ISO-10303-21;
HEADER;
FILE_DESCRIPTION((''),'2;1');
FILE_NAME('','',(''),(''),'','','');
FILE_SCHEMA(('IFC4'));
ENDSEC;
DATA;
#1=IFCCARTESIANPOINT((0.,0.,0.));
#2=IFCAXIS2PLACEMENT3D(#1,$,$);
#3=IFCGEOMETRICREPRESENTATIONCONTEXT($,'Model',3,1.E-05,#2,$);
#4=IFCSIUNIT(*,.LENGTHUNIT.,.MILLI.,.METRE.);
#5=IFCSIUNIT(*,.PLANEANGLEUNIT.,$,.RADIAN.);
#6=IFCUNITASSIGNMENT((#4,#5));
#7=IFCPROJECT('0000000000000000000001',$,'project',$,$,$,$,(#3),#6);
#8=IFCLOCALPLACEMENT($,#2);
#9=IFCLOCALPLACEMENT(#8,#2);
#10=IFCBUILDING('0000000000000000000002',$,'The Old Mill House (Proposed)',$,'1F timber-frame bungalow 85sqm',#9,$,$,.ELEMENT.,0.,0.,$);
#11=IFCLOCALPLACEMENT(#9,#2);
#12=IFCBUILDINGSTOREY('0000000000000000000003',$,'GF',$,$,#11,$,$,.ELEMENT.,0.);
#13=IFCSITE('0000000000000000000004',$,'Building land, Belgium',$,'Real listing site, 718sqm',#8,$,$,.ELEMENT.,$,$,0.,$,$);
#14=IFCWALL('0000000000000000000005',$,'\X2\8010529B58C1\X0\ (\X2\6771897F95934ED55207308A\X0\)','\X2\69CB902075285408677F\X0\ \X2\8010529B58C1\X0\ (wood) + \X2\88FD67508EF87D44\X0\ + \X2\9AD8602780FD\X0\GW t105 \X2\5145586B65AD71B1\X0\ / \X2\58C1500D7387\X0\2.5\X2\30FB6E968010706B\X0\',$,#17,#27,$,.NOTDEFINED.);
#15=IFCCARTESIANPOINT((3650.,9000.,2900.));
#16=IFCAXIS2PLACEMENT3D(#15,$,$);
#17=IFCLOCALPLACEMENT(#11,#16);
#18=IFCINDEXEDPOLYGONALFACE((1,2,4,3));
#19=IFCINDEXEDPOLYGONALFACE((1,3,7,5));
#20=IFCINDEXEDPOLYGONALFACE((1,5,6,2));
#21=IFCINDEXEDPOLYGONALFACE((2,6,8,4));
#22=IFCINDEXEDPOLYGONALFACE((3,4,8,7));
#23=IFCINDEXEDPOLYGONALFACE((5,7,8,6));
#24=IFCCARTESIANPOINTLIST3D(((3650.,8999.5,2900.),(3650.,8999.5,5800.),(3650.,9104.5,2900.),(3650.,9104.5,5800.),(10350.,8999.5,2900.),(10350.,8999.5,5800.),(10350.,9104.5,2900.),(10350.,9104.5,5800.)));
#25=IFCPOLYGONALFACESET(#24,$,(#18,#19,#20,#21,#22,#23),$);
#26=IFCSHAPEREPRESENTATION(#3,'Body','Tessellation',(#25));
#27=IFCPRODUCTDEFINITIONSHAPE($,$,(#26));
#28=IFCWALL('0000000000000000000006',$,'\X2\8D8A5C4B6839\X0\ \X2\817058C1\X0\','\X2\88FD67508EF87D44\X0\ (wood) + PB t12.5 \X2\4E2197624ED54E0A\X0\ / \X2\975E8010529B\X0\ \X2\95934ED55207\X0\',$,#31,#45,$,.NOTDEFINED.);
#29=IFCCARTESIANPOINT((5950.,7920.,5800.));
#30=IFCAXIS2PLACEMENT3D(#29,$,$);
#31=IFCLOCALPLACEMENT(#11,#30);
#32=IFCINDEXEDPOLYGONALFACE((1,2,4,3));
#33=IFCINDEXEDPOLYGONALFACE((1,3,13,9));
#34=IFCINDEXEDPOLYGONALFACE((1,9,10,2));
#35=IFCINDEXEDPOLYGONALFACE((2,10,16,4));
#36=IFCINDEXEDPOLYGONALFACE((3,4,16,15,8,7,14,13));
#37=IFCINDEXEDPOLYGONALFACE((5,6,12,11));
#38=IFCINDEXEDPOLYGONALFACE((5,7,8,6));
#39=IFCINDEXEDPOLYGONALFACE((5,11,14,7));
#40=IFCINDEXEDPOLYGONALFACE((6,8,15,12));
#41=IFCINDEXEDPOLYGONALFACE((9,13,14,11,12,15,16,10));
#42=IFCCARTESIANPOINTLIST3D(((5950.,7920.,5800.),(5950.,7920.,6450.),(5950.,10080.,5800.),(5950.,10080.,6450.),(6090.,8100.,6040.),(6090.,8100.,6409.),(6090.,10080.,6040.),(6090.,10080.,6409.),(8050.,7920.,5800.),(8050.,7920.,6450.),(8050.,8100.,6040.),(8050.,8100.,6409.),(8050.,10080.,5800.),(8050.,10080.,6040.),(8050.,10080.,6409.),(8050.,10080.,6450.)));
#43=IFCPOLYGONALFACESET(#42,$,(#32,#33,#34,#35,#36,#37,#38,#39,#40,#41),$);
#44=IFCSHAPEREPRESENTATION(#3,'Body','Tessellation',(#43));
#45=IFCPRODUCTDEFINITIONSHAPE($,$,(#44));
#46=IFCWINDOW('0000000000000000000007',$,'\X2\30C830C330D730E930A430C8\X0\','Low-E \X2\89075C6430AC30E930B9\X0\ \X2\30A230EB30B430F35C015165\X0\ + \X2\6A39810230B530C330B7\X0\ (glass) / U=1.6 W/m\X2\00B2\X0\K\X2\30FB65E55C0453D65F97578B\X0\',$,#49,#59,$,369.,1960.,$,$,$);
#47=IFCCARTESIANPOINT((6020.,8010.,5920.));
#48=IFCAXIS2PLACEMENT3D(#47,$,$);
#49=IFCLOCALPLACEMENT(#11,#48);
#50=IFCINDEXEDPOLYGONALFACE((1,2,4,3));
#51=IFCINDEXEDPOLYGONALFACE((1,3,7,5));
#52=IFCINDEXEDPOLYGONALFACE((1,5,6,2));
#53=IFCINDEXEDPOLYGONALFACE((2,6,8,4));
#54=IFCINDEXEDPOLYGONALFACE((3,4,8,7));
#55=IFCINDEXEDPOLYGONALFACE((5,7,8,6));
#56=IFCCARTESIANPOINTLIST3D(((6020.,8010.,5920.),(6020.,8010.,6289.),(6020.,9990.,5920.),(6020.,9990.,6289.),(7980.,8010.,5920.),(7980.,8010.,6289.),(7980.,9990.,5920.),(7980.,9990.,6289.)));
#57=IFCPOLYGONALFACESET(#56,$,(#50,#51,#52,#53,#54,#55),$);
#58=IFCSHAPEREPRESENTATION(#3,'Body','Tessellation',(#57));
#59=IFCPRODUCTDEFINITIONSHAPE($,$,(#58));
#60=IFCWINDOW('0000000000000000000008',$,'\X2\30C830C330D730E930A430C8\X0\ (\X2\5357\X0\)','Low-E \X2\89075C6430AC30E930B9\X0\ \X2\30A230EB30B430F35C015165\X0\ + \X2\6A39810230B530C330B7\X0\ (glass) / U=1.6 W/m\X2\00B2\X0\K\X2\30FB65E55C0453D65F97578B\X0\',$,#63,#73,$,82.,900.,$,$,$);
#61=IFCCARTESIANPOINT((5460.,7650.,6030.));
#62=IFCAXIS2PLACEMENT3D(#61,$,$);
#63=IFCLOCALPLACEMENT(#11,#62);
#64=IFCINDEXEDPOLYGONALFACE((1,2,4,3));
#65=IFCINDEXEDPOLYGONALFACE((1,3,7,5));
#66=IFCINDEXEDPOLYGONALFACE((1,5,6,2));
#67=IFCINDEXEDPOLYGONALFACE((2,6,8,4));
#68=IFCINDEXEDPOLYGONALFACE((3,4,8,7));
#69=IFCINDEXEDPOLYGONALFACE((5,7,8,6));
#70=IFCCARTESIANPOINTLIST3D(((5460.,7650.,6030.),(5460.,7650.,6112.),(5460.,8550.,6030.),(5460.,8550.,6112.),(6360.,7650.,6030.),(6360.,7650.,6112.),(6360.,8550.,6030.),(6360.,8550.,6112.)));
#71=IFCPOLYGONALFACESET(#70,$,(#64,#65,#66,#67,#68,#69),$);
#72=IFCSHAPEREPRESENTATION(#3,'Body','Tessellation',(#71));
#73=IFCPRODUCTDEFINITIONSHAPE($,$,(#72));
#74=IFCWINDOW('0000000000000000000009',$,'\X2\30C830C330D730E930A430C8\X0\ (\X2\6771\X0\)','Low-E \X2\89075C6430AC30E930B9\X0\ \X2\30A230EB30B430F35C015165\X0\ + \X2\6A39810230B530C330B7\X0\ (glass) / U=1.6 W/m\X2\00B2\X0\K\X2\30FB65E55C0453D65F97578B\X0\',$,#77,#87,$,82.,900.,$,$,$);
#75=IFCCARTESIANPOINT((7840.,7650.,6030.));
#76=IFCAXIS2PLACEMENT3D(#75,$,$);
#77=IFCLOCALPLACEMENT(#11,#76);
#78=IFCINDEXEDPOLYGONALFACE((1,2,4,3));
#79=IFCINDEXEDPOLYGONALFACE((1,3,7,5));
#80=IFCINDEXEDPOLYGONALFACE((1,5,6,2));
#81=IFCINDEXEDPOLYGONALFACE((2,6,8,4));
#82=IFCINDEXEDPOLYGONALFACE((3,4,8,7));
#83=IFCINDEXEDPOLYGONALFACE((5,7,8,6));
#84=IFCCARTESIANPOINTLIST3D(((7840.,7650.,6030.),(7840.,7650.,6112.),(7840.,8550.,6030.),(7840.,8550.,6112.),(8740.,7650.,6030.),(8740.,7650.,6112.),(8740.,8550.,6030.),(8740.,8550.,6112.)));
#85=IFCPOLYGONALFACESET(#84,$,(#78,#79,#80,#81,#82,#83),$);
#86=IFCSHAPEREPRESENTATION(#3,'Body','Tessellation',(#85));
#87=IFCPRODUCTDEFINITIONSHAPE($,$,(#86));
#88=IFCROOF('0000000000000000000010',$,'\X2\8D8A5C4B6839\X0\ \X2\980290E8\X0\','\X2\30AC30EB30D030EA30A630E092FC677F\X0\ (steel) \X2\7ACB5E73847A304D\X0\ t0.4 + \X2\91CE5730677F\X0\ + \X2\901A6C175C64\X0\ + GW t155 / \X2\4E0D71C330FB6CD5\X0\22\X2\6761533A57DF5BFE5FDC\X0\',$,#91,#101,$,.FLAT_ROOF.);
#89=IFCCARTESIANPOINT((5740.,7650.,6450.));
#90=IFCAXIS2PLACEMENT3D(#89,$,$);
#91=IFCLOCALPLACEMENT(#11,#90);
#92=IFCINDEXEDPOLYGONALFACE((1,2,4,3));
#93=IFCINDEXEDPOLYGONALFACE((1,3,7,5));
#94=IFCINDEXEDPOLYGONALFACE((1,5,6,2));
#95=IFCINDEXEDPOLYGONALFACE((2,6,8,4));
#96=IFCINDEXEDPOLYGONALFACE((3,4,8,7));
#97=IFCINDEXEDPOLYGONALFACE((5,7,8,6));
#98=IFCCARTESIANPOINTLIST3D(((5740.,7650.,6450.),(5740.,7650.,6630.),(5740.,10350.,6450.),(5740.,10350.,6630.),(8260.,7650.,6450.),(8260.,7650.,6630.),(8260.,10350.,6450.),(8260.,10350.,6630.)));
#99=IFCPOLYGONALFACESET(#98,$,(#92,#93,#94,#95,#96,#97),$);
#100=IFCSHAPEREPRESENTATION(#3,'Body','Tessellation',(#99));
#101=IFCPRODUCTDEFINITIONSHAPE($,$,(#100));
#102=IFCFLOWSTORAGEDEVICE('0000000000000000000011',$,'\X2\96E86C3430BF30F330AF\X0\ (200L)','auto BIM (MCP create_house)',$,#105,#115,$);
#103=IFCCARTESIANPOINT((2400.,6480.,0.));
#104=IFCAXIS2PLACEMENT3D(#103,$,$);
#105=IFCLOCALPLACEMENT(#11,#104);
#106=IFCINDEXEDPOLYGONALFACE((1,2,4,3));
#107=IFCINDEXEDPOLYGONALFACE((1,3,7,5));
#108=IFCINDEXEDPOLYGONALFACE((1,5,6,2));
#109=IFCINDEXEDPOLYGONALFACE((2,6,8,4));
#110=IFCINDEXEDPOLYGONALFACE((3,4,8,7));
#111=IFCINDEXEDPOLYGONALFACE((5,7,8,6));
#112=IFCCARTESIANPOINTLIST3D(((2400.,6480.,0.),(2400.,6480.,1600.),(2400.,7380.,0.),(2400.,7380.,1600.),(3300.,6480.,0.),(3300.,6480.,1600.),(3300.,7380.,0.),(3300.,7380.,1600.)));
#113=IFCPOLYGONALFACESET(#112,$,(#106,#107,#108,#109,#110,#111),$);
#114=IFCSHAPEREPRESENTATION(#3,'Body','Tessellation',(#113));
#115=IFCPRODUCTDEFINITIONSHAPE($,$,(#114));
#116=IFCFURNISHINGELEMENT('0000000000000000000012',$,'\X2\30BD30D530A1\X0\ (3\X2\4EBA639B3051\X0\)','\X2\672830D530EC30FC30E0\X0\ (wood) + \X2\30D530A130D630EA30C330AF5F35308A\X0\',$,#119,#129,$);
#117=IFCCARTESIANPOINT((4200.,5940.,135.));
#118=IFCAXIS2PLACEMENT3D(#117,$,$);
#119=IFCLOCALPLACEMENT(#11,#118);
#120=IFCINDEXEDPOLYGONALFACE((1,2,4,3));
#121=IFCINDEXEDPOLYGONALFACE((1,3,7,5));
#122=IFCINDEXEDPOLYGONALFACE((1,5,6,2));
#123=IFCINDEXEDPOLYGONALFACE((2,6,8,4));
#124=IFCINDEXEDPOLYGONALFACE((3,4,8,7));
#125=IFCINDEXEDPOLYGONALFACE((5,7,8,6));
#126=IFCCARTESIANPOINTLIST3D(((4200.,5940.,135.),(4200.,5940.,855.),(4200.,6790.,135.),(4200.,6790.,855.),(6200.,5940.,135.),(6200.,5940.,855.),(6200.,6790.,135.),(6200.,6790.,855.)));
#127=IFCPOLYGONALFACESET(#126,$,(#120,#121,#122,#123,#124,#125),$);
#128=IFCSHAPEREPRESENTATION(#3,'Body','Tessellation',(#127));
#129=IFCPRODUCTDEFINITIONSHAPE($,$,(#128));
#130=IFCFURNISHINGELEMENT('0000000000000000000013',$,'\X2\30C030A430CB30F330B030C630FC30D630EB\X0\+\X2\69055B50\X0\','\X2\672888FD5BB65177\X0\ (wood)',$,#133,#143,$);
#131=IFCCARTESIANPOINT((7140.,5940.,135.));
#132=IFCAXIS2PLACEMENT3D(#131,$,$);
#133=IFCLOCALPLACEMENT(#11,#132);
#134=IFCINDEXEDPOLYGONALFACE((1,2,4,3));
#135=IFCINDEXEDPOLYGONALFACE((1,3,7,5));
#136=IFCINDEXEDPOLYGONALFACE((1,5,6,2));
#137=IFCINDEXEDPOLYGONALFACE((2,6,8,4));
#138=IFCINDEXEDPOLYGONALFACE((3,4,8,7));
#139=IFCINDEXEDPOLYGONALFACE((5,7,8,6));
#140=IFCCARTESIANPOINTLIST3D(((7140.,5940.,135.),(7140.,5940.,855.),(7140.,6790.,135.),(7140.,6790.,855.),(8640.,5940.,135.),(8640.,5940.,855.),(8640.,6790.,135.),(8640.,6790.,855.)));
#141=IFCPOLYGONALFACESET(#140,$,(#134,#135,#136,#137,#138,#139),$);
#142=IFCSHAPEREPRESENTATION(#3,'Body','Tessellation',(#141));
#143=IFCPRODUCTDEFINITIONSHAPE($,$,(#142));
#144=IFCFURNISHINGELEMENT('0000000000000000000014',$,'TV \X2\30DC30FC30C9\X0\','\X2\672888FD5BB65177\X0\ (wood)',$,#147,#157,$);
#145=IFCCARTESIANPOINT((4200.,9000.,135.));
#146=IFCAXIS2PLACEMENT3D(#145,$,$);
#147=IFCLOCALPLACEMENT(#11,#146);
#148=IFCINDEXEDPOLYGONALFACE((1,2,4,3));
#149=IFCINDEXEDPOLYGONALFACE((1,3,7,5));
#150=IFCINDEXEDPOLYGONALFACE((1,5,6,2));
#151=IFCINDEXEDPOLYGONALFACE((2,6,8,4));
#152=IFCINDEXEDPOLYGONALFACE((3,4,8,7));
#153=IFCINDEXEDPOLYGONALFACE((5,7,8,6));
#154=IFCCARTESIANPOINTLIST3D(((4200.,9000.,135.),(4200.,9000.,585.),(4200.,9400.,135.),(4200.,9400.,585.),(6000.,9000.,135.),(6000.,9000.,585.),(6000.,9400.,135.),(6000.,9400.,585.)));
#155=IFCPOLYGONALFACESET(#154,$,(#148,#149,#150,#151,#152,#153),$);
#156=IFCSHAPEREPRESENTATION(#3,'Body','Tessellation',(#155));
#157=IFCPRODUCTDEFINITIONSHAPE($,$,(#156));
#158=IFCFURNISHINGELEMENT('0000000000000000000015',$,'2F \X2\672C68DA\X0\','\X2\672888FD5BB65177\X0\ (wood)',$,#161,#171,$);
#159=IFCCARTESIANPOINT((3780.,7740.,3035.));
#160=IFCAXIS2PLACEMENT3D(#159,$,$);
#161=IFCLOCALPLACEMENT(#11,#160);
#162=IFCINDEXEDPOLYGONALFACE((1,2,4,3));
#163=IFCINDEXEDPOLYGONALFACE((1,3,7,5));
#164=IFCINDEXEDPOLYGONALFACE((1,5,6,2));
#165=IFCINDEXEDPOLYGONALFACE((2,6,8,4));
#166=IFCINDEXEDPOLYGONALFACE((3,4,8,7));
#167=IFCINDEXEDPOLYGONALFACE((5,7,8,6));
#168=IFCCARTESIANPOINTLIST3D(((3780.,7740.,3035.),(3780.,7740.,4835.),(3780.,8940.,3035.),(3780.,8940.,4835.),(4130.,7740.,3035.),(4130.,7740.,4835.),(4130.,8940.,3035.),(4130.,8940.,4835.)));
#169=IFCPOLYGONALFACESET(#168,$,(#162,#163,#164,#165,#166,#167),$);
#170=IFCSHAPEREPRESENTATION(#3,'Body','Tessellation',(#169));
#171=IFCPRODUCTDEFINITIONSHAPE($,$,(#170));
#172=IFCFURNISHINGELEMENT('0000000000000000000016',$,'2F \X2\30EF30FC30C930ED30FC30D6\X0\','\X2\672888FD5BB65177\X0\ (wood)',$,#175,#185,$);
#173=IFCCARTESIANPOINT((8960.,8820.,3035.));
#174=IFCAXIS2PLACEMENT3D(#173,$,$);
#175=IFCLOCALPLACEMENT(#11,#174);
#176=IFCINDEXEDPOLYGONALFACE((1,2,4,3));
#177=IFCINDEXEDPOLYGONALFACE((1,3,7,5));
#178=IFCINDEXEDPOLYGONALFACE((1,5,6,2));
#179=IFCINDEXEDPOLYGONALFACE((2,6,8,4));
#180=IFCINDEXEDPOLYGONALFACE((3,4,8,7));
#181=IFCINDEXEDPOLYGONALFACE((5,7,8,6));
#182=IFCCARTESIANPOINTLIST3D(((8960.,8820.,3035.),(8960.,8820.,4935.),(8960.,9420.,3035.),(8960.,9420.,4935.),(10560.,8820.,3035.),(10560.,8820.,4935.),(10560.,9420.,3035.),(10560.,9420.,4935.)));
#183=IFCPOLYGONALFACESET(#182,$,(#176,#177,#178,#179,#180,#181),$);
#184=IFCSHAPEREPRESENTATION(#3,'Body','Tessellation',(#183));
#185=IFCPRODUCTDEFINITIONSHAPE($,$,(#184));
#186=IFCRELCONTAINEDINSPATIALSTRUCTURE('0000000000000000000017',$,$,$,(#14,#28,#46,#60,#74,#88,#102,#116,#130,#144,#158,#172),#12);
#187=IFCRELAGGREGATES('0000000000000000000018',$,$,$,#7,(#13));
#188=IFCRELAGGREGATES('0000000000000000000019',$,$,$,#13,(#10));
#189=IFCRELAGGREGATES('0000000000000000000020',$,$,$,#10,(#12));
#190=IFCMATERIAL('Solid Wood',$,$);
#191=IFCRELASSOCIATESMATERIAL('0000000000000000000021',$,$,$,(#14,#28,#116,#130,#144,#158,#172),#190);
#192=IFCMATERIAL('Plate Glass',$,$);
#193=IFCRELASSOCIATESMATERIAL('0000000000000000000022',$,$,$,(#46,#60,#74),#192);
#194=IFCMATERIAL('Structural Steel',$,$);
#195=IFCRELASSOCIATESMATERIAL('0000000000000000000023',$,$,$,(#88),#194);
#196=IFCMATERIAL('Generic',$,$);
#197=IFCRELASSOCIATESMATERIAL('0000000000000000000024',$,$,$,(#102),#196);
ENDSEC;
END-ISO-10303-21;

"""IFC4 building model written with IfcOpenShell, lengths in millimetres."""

from ifc_helpers import new_model, si_unit, frame, frame_2d, origin, place, context, project, spatial, rectangle, extrude, material, element, fill, save


model = new_model("IFC4")

# Units and contexts
model_context = context("Model", 3, precision=1e-05, world=origin())
ifc_project = project(units=[si_unit("LENGTHUNIT", "METRE", prefix="MILLI"), si_unit("PLANEANGLEUNIT", "RADIAN")], contexts=[model_context])

# Site, building, storey
site_placement = place(None, origin())
site = spatial("IfcSite", under=ifc_project, at=site_placement, Name="Building land, Belgium", ObjectType="Real listing site, 718sqm", CompositionType="ELEMENT", RefElevation=0.0)
building_placement = place(site_placement, origin())
building = spatial("IfcBuilding", under=site, at=building_placement, Name="The Old Mill House (Proposed)", ObjectType="1F timber-frame bungalow 85sqm", CompositionType="ELEMENT", ElevationOfRefHeight=0.0, ElevationOfTerrain=0.0)
storey_placement = place(building_placement, origin())
storey = spatial("IfcBuildingStorey", under=building, at=storey_placement, Name="GF", CompositionType="ELEMENT", Elevation=0.0)

# Wall
ifc_material_1 = material(Name="Solid Wood")
wall_1_placement = place(storey_placement, frame((3650.0, 9000.0, 2900.0)))
element("IfcWall", 1, at=wall_1_placement, inside=storey, material=ifc_material_1, Name="耐力壁 (東西間仕切り)", Description="構造用合板 耐力壁 (wood) + 製材軸組 + 高性能GW t105 充填断熱 / 壁倍率2.5・準耐火", PredefinedType="NOTDEFINED", context=model_context, shape_type="SweptSolid", body=[
    extrude(rectangle(XDim=6700.0, YDim=105.0, at=frame_2d((3350.0, 52.0))), frame((3650.0, 9000.0, 2900.0)), (0.0, 0.0, 1.0), 2900.0),
])

# Wall, openings, windows
wall_2_placement = place(storey_placement, frame((5950.0, 7920.0, 5800.0)))
wall_2 = element("IfcWall", 2, at=wall_2_placement, inside=storey, material=ifc_material_1, Name="越屋根 腰壁", Description="製材軸組 (wood) + PB t12.5 両面仕上 / 非耐力 間仕切", PredefinedType="NOTDEFINED", context=model_context, shape_type="SweptSolid", body=[
    extrude(rectangle(XDim=2100.0, YDim=2160.0, at=frame_2d((1050.0, 1080.0))), frame((5950.0, 7920.0, 5800.0)), (0.0, 0.0, 1.0), 650.0),
])
opening_1_placement = place(storey_placement, frame((6020.0, 8010.0, 5920.0)))
opening_1 = element("IfcOpeningElement", 3, at=opening_1_placement, cuts=wall_2, PredefinedType="NOTDEFINED", context=model_context, shape_type="SweptSolid", body=[
    extrude(rectangle(XDim=1960.0, YDim=1980.0, at=frame_2d((980.0, 990.0))), frame((6020.0, 8010.0, 5920.0)), (0.0, 0.0, 1.0), 369.0),
])
opening_2_placement = place(storey_placement, frame((5460.0, 7650.0, 6030.0)))
opening_2 = element("IfcOpeningElement", 4, at=opening_2_placement, cuts=wall_2, PredefinedType="NOTDEFINED", context=model_context, shape_type="SweptSolid", body=[
    extrude(rectangle(XDim=900.0, YDim=900.0, at=frame_2d((450.0, 450.0))), frame((5460.0, 7650.0, 6030.0)), (0.0, 0.0, 1.0), 82.0),
])
opening_3_placement = place(storey_placement, frame((7840.0, 7650.0, 6030.0)))
opening_3 = element("IfcOpeningElement", 5, at=opening_3_placement, cuts=wall_2, PredefinedType="NOTDEFINED", context=model_context, shape_type="SweptSolid", body=[
    extrude(rectangle(XDim=900.0, YDim=900.0, at=frame_2d((450.0, 450.0))), frame((7840.0, 7650.0, 6030.0)), (0.0, 0.0, 1.0), 82.0),
])
ifc_material_2 = material(Name="Plate Glass")
window_1_placement = place(storey_placement, frame((6020.0, 8010.0, 5920.0)))
window_1 = element("IfcWindow", 6, at=window_1_placement, inside=storey, material=ifc_material_2, Name="トップライト", Description="Low-E 複層ガラス アルゴン封入 + 樹脂サッシ (glass) / U=1.6 W/m²K・日射取得型", OverallHeight=369.0, OverallWidth=1960.0, context=model_context, shape_type="SweptSolid", body=[
    extrude(rectangle(XDim=1960.0, YDim=1980.0, at=frame_2d((980.0, 990.0))), frame((6020.0, 8010.0, 5920.0)), (0.0, 0.0, 1.0), 369.0),
])
fill(opening_1, window_1)
window_2_placement = place(storey_placement, frame((5460.0, 7650.0, 6030.0)))
window_2 = element("IfcWindow", 7, at=window_2_placement, inside=storey, material=ifc_material_2, Name="トップライト (南)", Description="Low-E 複層ガラス アルゴン封入 + 樹脂サッシ (glass) / U=1.6 W/m²K・日射取得型", OverallHeight=82.0, OverallWidth=900.0, context=model_context, shape_type="SweptSolid", body=[
    extrude(rectangle(XDim=900.0, YDim=900.0, at=frame_2d((450.0, 450.0))), frame((5460.0, 7650.0, 6030.0)), (0.0, 0.0, 1.0), 82.0),
])
fill(opening_2, window_2)
window_3_placement = place(storey_placement, frame((7840.0, 7650.0, 6030.0)))
window_3 = element("IfcWindow", 8, at=window_3_placement, inside=storey, material=ifc_material_2, Name="トップライト (東)", Description="Low-E 複層ガラス アルゴン封入 + 樹脂サッシ (glass) / U=1.6 W/m²K・日射取得型", OverallHeight=82.0, OverallWidth=900.0, context=model_context, shape_type="SweptSolid", body=[
    extrude(rectangle(XDim=900.0, YDim=900.0, at=frame_2d((450.0, 450.0))), frame((7840.0, 7650.0, 6030.0)), (0.0, 0.0, 1.0), 82.0),
])
fill(opening_3, window_3)

# Roof
ifc_material_3 = material(Name="Structural Steel")
roof_placement = place(storey_placement, frame((5740.0, 7650.0, 6450.0)))
element("IfcRoof", 9, at=roof_placement, inside=storey, material=ifc_material_3, Name="越屋根 頂部", Description="ガルバリウム鋼板 (steel) 立平葺き t0.4 + 野地板 + 通気層 + GW t155 / 不燃・法22条区域対応", PredefinedType="FLAT_ROOF", context=model_context, shape_type="SweptSolid", body=[
    extrude(rectangle(XDim=2520.0, YDim=2700.0, at=frame_2d((1260.0, 1350.0))), frame((5740.0, 7650.0, 6450.0)), (0.0, 0.0, 1.0), 180.0),
])

# Flow storage device
ifc_material_4 = material(Name="Generic")
flow_storage_device_placement = place(storey_placement, frame((2400.0, 6480.0, 0.0)))
element("IfcFlowStorageDevice", 10, at=flow_storage_device_placement, inside=storey, material=ifc_material_4, Name="雨水タンク (200L)", Description="auto BIM (MCP create_house)", context=model_context, shape_type="SweptSolid", body=[
    extrude(rectangle(XDim=900.0, YDim=900.0, at=frame_2d((450.0, 450.0))), frame((2400.0, 6480.0, 0.0)), (0.0, 0.0, 1.0), 1600.0),
])

# Furnishing elements
furnishing_1_placement = place(storey_placement, frame((4200.0, 5940.0, 135.0)))
element("IfcFurnishingElement", 11, at=furnishing_1_placement, inside=storey, material=ifc_material_1, Name="ソファ (3人掛け)", Description="木フレーム (wood) + ファブリック張り", context=model_context, shape_type="SweptSolid", body=[
    extrude(rectangle(XDim=2000.0, YDim=850.0, at=frame_2d((1000.0, 425.0))), frame((4200.0, 5940.0, 135.0)), (0.0, 0.0, 1.0), 720.0),
])
furnishing_2_placement = place(storey_placement, frame((7140.0, 5940.0, 135.0)))
element("IfcFurnishingElement", 12, at=furnishing_2_placement, inside=storey, material=ifc_material_1, Name="ダイニングテーブル+椅子", Description="木製家具 (wood)", context=model_context, shape_type="SweptSolid", body=[
    extrude(rectangle(XDim=1500.0, YDim=850.0, at=frame_2d((750.0, 425.0))), frame((7140.0, 5940.0, 135.0)), (0.0, 0.0, 1.0), 720.0),
])
furnishing_3_placement = place(storey_placement, frame((4200.0, 9000.0, 135.0)))
element("IfcFurnishingElement", 13, at=furnishing_3_placement, inside=storey, material=ifc_material_1, Name="TV ボード", Description="木製家具 (wood)", context=model_context, shape_type="SweptSolid", body=[
    extrude(rectangle(XDim=1800.0, YDim=400.0, at=frame_2d((900.0, 200.0))), frame((4200.0, 9000.0, 135.0)), (0.0, 0.0, 1.0), 450.0),
])
furnishing_4_placement = place(storey_placement, frame((3780.0, 7740.0, 3035.0)))
element("IfcFurnishingElement", 14, at=furnishing_4_placement, inside=storey, material=ifc_material_1, Name="2F 本棚", Description="木製家具 (wood)", context=model_context, shape_type="SweptSolid", body=[
    extrude(rectangle(XDim=350.0, YDim=1200.0, at=frame_2d((175.0, 600.0))), frame((3780.0, 7740.0, 3035.0)), (0.0, 0.0, 1.0), 1800.0),
])
furnishing_5_placement = place(storey_placement, frame((8960.0, 8820.0, 3035.0)))
element("IfcFurnishingElement", 15, at=furnishing_5_placement, inside=storey, material=ifc_material_1, Name="2F ワードローブ", Description="木製家具 (wood)", context=model_context, shape_type="SweptSolid", body=[
    extrude(rectangle(XDim=1600.0, YDim=600.0, at=frame_2d((800.0, 300.0))), frame((8960.0, 8820.0, 3035.0)), (0.0, 0.0, 1.0), 1900.0),
])

save(model, "model.ifc")
